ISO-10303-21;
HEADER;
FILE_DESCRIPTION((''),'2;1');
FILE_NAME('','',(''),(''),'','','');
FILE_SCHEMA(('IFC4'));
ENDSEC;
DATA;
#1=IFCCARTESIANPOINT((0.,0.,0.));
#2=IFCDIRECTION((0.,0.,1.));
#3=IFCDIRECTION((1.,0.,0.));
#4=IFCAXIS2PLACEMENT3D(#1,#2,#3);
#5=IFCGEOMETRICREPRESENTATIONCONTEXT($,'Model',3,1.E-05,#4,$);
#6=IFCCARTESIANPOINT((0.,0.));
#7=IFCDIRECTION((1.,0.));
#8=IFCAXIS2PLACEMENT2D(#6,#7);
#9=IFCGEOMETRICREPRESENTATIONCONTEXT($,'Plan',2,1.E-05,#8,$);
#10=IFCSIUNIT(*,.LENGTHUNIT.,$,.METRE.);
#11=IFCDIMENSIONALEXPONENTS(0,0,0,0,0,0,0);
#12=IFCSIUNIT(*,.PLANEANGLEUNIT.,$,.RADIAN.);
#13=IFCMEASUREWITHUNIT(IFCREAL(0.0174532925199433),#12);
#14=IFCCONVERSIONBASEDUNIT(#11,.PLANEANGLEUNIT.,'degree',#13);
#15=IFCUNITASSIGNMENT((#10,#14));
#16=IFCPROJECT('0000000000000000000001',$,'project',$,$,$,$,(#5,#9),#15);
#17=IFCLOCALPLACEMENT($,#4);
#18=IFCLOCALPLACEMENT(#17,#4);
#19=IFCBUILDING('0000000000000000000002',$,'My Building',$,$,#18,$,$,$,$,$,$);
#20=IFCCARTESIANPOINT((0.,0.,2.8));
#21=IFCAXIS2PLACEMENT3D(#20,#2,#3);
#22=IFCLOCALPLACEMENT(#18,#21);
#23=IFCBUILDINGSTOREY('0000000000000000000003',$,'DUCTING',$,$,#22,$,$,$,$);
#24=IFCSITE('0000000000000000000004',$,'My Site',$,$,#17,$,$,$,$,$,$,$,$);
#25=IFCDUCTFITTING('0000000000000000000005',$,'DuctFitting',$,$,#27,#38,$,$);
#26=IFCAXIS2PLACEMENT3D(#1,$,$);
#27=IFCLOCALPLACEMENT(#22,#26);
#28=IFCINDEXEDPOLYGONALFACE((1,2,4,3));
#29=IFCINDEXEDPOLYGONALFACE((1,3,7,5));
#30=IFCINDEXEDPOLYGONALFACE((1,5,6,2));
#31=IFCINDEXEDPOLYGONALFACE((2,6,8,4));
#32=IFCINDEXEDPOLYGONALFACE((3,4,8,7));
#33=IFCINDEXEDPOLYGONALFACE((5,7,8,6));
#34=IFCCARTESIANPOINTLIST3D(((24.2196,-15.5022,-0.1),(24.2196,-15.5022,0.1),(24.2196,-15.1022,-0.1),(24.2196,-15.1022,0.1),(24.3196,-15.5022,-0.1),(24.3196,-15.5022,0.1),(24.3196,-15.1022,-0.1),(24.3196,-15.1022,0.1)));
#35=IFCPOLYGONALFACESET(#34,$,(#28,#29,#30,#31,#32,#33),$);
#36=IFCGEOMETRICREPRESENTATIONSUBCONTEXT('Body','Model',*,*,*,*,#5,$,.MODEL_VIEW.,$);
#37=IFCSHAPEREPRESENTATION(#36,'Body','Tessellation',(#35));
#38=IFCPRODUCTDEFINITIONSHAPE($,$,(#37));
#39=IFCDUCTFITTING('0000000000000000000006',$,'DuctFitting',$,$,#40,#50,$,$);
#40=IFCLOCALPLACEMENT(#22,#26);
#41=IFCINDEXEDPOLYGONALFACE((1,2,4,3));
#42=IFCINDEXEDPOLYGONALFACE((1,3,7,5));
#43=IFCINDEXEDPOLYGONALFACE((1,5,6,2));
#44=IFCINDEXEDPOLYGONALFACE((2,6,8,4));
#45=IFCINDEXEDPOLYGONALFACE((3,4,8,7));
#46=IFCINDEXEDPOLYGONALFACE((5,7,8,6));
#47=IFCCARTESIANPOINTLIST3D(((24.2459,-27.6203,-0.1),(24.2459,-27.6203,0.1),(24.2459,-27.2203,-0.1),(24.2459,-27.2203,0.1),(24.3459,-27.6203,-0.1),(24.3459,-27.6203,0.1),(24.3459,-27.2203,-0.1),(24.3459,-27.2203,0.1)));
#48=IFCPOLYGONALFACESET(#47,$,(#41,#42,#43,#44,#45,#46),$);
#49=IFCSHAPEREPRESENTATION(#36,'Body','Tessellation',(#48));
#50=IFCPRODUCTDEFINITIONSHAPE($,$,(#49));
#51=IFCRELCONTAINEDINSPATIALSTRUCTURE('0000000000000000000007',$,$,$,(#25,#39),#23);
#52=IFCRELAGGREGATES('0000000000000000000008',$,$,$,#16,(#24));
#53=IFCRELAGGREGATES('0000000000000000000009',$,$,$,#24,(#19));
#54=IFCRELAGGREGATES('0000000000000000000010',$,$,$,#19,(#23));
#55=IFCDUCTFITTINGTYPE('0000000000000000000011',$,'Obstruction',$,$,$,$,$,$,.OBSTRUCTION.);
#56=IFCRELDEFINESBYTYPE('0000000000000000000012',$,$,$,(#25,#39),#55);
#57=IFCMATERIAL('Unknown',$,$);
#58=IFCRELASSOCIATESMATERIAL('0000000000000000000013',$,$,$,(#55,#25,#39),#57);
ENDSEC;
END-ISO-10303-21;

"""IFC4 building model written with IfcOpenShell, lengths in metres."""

from ifc_helpers import new_model, entity, si_unit, converted_unit, frame, origin_with_axes, origin_2d_with_axis, place, context, subcontext, project, spatial, rectangle, extrude, material, material_profile, profile_set, profile_usage, type_object, element, save


model = new_model("IFC4")

# Units and contexts
model_context = context("Model", 3, precision=1e-05, world=origin_with_axes())
plan_context = context("Plan", 2, precision=1e-05, world=origin_2d_with_axis())
body_context = subcontext(model_context, "Body", "Model", "MODEL_VIEW")
ifc_project = project(units=[si_unit("LENGTHUNIT", "METRE"), converted_unit("PLANEANGLEUNIT", "degree", entity("IfcReal", 0.0174532925199433), si_unit("PLANEANGLEUNIT", "RADIAN"), dimensions=[0, 0, 0, 0, 0, 0, 0])], contexts=[model_context, plan_context])

# Site, building, storey
site_placement = place(None, origin_with_axes())
site = spatial("IfcSite", under=ifc_project, at=site_placement, Name="My Site")
building_placement = place(site_placement, origin_with_axes())
building = spatial("IfcBuilding", under=site, at=building_placement, Name="My Building")
storey_placement = place(building_placement, frame((0.0, 0.0, 2.8), z_axis=(0.0, 0.0, 1.0), x_axis=(1.0, 0.0, 0.0)))
storey = spatial("IfcBuildingStorey", under=building, at=storey_placement, Name="DUCTING")

# Shared definitions
ifc_material = material(Name="Unknown")

# Duct fittings
ifc_material_profile_1 = material_profile(ifc_material, rectangle(XDim=0.4, YDim=0.2))
ifc_profile_set_1 = profile_set([ifc_material_profile_1])
duct_fitting_type_1 = type_object("IfcDuctFittingType", Name="Obstruction", PredefinedType="OBSTRUCTION", material=ifc_profile_set_1)
ifc_profile_usage_1 = profile_usage(ifc_profile_set_1, cardinal=5)
duct_fitting_1_placement = place(storey_placement, frame((24.2196, -15.3022, 0.0), z_axis=(1.0, -0.000001, 0.000001), x_axis=(0.000001, 1.0, 0.0)))
element("IfcDuctFitting", 1, at=duct_fitting_1_placement, inside=storey, type_object=duct_fitting_type_1, material=ifc_profile_usage_1, Name="DuctFitting", context=body_context, shape_type="SweptSolid", body=[
    extrude(rectangle(XDim=0.4, YDim=0.2), origin_with_axes(), (0.0, 0.0, 1.0), 0.1),
])
ifc_profile_usage_2 = profile_usage(ifc_profile_set_1, cardinal=5)
duct_fitting_2_placement = place(storey_placement, frame((24.2459, -27.4203, 0.0), z_axis=(1.0, -0.000001, 0.000001), x_axis=(0.000001, 1.0, 0.0)))
element("IfcDuctFitting", 2, at=duct_fitting_2_placement, inside=storey, type_object=duct_fitting_type_1, material=ifc_profile_usage_2, Name="DuctFitting", context=body_context, shape_type="SweptSolid", body=[
    extrude(rectangle(XDim=0.4, YDim=0.2), origin_with_axes(), (0.0, 0.0, 1.0), 0.1),
])

save(model, "model.ifc")
